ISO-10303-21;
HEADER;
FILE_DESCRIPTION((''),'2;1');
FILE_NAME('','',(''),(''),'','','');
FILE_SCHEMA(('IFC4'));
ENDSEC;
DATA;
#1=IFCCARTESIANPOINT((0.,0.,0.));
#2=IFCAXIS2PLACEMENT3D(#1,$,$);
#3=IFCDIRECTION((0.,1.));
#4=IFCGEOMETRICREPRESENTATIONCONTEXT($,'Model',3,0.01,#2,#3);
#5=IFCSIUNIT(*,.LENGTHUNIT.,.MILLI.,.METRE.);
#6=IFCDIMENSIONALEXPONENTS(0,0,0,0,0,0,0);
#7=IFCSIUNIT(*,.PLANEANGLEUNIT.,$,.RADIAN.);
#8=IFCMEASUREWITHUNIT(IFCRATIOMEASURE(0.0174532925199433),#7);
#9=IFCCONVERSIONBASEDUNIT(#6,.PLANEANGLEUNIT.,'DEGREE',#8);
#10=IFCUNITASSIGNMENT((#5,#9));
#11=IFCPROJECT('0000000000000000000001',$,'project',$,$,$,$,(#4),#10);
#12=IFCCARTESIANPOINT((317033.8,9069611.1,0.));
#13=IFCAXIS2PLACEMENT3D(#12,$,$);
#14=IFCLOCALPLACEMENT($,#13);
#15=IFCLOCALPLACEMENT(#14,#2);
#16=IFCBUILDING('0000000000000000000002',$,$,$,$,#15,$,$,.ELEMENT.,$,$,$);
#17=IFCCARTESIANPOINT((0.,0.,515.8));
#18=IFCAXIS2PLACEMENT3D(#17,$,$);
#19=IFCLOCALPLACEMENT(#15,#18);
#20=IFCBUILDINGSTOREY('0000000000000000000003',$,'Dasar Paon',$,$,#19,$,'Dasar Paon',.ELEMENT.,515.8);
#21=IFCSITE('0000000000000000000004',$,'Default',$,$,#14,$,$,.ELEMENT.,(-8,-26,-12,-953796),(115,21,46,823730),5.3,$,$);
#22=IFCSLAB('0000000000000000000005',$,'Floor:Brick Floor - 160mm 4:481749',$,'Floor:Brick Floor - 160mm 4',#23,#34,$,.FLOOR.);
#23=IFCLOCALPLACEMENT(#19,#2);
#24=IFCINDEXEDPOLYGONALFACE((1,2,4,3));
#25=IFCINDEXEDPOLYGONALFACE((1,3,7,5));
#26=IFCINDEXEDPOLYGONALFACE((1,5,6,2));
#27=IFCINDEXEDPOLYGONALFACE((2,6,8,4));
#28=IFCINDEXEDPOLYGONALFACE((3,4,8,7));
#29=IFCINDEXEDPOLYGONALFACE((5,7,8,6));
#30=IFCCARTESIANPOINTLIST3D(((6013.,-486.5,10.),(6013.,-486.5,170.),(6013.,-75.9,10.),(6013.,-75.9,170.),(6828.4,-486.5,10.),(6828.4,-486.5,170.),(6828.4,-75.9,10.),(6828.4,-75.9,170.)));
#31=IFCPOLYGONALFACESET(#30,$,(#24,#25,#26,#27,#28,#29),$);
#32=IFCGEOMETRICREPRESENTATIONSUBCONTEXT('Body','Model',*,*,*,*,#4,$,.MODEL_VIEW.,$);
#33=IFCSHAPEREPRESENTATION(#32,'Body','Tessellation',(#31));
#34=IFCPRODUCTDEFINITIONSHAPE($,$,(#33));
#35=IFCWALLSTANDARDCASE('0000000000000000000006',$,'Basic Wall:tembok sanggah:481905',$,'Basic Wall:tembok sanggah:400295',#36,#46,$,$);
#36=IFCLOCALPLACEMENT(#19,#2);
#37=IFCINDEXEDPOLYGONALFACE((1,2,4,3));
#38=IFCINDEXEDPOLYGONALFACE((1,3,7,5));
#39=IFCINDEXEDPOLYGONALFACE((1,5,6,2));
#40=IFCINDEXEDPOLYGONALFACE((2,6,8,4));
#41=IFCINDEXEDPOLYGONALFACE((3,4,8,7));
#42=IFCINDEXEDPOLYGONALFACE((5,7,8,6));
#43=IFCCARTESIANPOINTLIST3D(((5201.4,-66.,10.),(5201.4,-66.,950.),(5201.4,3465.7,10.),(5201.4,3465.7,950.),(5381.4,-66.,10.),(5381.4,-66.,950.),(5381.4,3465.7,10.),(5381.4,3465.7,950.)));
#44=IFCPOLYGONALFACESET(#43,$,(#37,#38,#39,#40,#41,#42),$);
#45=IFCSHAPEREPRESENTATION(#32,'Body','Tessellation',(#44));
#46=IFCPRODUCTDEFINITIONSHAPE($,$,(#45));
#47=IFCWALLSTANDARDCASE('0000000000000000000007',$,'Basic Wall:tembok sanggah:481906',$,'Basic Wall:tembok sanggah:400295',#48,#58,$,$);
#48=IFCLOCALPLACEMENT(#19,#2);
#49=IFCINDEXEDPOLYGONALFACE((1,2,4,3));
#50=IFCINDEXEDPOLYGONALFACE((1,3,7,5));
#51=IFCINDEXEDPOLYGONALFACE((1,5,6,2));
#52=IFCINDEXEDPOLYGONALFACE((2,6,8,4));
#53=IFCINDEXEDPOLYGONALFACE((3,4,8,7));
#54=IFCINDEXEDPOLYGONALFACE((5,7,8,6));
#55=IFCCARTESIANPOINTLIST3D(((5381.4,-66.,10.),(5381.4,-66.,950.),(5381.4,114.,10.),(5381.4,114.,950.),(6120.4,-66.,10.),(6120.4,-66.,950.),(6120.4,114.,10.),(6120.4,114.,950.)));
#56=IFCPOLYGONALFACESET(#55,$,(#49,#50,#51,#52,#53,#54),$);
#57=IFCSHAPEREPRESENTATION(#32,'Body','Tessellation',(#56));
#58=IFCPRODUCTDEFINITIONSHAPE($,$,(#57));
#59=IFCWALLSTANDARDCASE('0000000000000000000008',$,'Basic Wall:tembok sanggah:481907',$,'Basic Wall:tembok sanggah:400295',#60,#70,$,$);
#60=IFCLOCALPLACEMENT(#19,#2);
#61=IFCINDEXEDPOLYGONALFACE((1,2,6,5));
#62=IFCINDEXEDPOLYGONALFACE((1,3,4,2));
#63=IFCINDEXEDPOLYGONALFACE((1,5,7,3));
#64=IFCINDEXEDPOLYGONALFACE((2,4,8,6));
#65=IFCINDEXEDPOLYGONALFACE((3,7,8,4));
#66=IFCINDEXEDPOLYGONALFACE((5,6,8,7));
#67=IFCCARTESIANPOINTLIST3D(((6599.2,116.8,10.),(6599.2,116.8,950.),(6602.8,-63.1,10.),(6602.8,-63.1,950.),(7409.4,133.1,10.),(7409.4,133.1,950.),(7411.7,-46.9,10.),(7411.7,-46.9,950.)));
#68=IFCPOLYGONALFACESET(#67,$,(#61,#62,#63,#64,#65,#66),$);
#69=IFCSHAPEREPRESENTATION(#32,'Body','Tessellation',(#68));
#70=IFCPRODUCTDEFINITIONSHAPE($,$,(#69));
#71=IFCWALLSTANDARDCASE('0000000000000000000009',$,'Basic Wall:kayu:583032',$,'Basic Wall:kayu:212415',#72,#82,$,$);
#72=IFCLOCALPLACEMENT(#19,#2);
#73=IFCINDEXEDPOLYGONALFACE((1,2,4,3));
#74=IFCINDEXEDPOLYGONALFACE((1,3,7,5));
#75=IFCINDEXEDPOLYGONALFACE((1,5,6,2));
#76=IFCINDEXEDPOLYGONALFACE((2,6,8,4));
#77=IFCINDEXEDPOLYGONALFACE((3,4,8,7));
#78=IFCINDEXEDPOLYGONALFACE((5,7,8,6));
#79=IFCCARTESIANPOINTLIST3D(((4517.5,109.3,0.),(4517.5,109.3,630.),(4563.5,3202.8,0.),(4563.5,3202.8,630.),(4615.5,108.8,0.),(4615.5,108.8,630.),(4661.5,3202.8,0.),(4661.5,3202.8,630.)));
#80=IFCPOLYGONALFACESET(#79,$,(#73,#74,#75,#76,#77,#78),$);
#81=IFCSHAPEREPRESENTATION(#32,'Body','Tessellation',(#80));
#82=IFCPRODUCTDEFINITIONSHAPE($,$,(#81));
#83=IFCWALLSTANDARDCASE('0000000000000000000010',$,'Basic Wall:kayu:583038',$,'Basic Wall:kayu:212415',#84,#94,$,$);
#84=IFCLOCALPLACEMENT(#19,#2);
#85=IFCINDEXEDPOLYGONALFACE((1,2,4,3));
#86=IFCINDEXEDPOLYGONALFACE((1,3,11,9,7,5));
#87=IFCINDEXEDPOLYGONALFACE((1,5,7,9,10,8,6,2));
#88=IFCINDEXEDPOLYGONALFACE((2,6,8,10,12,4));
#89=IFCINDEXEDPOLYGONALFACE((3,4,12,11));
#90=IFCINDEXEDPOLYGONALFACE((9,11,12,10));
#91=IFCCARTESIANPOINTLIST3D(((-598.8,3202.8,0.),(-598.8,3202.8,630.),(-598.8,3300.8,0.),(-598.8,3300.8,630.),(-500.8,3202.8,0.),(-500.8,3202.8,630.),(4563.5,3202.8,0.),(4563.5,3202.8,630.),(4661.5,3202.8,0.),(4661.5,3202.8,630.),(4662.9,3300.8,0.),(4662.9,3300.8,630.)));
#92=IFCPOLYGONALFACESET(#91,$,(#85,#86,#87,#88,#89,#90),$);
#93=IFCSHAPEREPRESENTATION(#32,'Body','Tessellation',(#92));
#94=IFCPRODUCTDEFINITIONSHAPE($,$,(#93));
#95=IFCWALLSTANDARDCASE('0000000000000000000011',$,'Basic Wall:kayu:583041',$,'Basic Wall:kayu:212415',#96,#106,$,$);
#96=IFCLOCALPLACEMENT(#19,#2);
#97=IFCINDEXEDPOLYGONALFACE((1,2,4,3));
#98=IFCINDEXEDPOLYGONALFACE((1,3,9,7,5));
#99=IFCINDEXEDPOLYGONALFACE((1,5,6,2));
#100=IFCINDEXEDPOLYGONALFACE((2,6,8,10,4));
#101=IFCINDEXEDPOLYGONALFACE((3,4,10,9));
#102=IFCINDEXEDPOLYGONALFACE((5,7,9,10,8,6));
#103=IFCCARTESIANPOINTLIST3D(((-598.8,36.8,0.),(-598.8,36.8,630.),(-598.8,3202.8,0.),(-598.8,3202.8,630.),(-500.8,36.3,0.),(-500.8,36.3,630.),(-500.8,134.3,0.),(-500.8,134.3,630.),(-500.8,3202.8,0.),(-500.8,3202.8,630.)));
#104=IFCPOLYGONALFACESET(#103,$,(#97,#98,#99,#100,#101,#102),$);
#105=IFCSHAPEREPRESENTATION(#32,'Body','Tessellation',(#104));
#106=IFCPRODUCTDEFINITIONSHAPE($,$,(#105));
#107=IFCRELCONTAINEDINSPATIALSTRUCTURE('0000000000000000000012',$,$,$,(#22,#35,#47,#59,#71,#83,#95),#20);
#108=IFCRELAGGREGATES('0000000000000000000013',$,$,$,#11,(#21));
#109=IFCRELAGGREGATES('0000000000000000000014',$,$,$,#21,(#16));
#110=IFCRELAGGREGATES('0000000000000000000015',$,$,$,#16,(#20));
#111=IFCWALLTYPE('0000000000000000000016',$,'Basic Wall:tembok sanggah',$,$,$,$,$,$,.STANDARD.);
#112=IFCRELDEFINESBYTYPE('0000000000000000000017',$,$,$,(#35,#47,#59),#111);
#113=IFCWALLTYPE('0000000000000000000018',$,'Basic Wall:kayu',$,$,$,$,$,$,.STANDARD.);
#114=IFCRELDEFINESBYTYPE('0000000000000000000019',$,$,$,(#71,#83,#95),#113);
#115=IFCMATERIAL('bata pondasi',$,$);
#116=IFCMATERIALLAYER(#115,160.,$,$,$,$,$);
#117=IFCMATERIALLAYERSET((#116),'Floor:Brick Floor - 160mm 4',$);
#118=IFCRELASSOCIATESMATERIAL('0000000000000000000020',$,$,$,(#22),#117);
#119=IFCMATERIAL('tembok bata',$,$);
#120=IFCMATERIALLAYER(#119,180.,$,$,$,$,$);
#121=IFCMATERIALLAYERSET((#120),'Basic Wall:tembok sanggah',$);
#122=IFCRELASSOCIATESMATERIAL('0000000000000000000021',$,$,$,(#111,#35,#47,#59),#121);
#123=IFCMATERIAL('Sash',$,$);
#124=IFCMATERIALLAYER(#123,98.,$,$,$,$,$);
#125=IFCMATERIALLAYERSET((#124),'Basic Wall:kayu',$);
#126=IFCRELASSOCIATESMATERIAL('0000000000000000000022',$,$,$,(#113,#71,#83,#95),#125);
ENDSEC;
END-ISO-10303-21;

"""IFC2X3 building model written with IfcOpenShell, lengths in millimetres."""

from ifc_helpers import new_model, entity, si_unit, converted_unit, direction, frame, frame_2d, origin, place, context, subcontext, project, spatial, polyline, rectangle, outline, extrude, material, layer, layer_set, layer_usage, type_object, element, save


model = new_model("IFC2X3")

# Units and contexts
model_context = context("Model", 3, precision=0.01, world=origin(), true_north=direction((0.0, 1.0)))
body_context = subcontext(model_context, "Body", "Model", "MODEL_VIEW")
ifc_project = project(units=[si_unit("LENGTHUNIT", "METRE", prefix="MILLI"), converted_unit("PLANEANGLEUNIT", "DEGREE", entity("IfcRatioMeasure", 0.0174532925199433), si_unit("PLANEANGLEUNIT", "RADIAN"), dimensions=[0, 0, 0, 0, 0, 0, 0])], contexts=[model_context])

# Site, building, storey
site_placement = place(None, frame((317033.8, 9069611.1, 0.0)))
site = spatial("IfcSite", under=ifc_project, at=site_placement, Name="Default", CompositionType="ELEMENT", RefLatitude=(-8, -26, -12, -953796), RefLongitude=(115, 21, 46, 823730), RefElevation=5.3)
building_placement = place(site_placement, origin())
building = spatial("IfcBuilding", under=site, at=building_placement, CompositionType="ELEMENT")
storey_placement = place(building_placement, frame((0.0, 0.0, 515.8)))
storey = spatial("IfcBuildingStorey", under=building, at=storey_placement, Name="Dasar Paon", LongName="Dasar Paon", CompositionType="ELEMENT", Elevation=515.8)

# Slab
ifc_material_1 = material(Name="bata pondasi")
ifc_layer_1 = layer(ifc_material_1, 160.0)
ifc_layer_set_1 = layer_set([ifc_layer_1], Name="Floor:Brick Floor - 160mm 4")
ifc_layer_usage_1 = layer_usage(ifc_layer_set_1, "AXIS3", "POSITIVE", 0.0)
slab_1_placement = place(storey_placement, origin())
element("IfcSlab", 1, at=slab_1_placement, inside=storey, material=ifc_layer_usage_1, Name="Floor:Brick Floor - 160mm 4:481749", ObjectType="Floor:Brick Floor - 160mm 4", PredefinedType="FLOOR", context=body_context, shape_type="SweptSolid", body=[
    extrude(rectangle(XDim=410.6, YDim=815.5, at=frame_2d((0.0, 0.0), x_axis=(1.0, 0.0))), frame((6420.7, -281.2, 170.0), z_axis=(0.0, 0.0, -1.0), x_axis=(0.0, 1.0, 0.0)), (0.0, 0.0, 1.0), 160.0),
])

# Walls
ifc_material_2 = material(Name="tembok bata")
ifc_layer_2 = layer(ifc_material_2, 180.0)
ifc_layer_set_2 = layer_set([ifc_layer_2], Name="Basic Wall:tembok sanggah")
ifc_layer_usage_2 = layer_usage(ifc_layer_set_2, "AXIS2", "NEGATIVE", 90.0)
wall_type_1 = type_object("IfcWallType", Name="Basic Wall:tembok sanggah", PredefinedType="STANDARD", material=ifc_layer_set_2)
wall_1_placement = place(storey_placement, frame((5291.4, 3465.7, 10.0), z_axis=(0.0, 0.0, 1.0), x_axis=(0.0, -1.0, 0.0)))
element("IfcWallStandardCase", 2, at=wall_1_placement, inside=storey, type_object=wall_type_1, material=ifc_layer_usage_2, Name="Basic Wall:tembok sanggah:481905", ObjectType="Basic Wall:tembok sanggah:400295", context=body_context, shape_type="SweptSolid", body=[
    extrude(rectangle(XDim=3531.8, YDim=180.0, at=frame_2d((1765.9, 0.0), x_axis=(-1.0, 0.0))), origin(), (0.0, 0.0, 1.0), 940.0),
])
ifc_layer_usage_3 = layer_usage(ifc_layer_set_2, "AXIS2", "NEGATIVE", 90.0)
wall_2_placement = place(storey_placement, frame((5381.4, 24.0, 10.0)))
element("IfcWallStandardCase", 3, at=wall_2_placement, inside=storey, type_object=wall_type_1, material=ifc_layer_usage_3, Name="Basic Wall:tembok sanggah:481906", ObjectType="Basic Wall:tembok sanggah:400295", context=body_context, shape_type="SweptSolid", body=[
    extrude(rectangle(XDim=739.0, YDim=180.0, at=frame_2d((369.5, 0.0), x_axis=(-1.0, 0.0))), origin(), (0.0, 0.0, 1.0), 940.0),
])
ifc_layer_usage_4 = layer_usage(ifc_layer_set_2, "AXIS2", "NEGATIVE", 90.0)
wall_3_placement = place(storey_placement, frame((6601.0, 26.9, 10.0), z_axis=(0.0, 0.0, 1.0), x_axis=(0.999798, 0.020086, 0.0)))
element("IfcWallStandardCase", 4, at=wall_3_placement, inside=storey, type_object=wall_type_1, material=ifc_layer_usage_4, Name="Basic Wall:tembok sanggah:481907", ObjectType="Basic Wall:tembok sanggah:400295", context=body_context, shape_type="SweptSolid", body=[
    extrude(outline(polyline([(809.1, -90.0), (810.4, 90.0), (0.0, 90.0), (0.0, -90.0), (809.1, -90.0)])), origin(), (0.0, 0.0, 1.0), 940.0),
])

# Shared definitions
ifc_material_3 = material(Name="Sash")

# Walls
ifc_layer_3 = layer(ifc_material_3, 98.0)
ifc_layer_set_3 = layer_set([ifc_layer_3], Name="Basic Wall:kayu")
ifc_layer_usage_5 = layer_usage(ifc_layer_set_3, "AXIS2", "NEGATIVE", 49.0)
wall_type_2 = type_object("IfcWallType", Name="Basic Wall:kayu", PredefinedType="STANDARD", material=ifc_layer_set_3)
wall_4_placement = place(storey_placement, frame((4566.5, 108.5, 0.0), z_axis=(0.0, 0.0, 1.0), x_axis=(0.014861, 0.99989, 0.0)))
element("IfcWallStandardCase", 5, at=wall_4_placement, inside=storey, type_object=wall_type_2, material=ifc_layer_usage_5, Name="Basic Wall:kayu:583032", ObjectType="Basic Wall:kayu:212415", context=body_context, shape_type="SweptSolid", body=[
    extrude(outline(polyline([(3095.3, -49.0), (3093.9, 49.0), (0.0, 49.0), (1.0, -49.0), (3095.3, -49.0)])), origin(), (0.0, 0.0, 1.0), 630.0),
])
ifc_layer_usage_6 = layer_usage(ifc_layer_set_3, "AXIS2", "POSITIVE", -49.0)
wall_5_placement = place(storey_placement, frame((4662.9, 3251.8, 0.0), z_axis=(0.0, 0.0, 1.0), x_axis=(-1.0, 0.0, 0.0)))
element("IfcWallStandardCase", 6, at=wall_5_placement, inside=storey, type_object=wall_type_2, material=ifc_layer_usage_6, Name="Basic Wall:kayu:583038", ObjectType="Basic Wall:kayu:212415", context=body_context, shape_type="SweptSolid", body=[
    extrude(outline(polyline([(5261.8, -49.0), (5261.8, 49.0), (5163.8, 49.0), (99.5, 49.0), (1.5, 49.0), (0.0, -49.0), (5261.8, -49.0)])), origin(), (0.0, 0.0, 1.0), 630.0),
])
ifc_layer_usage_7 = layer_usage(ifc_layer_set_3, "AXIS2", "POSITIVE", -49.0)
wall_6_placement = place(storey_placement, frame((-549.8, 3202.8, 0.0), z_axis=(0.0, 0.0, 1.0), x_axis=(0.0, -1.0, 0.0)))
element("IfcWallStandardCase", 7, at=wall_6_placement, inside=storey, type_object=wall_type_2, material=ifc_layer_usage_7, Name="Basic Wall:kayu:583041", ObjectType="Basic Wall:kayu:212415", context=body_context, shape_type="SweptSolid", body=[
    extrude(outline(polyline([(3166.0, -49.0), (3166.5, 49.0), (3068.5, 49.0), (0.0, 49.0), (0.0, -49.0), (3166.0, -49.0)])), origin(), (0.0, 0.0, 1.0), 630.0),
])

save(model, "model.ifc")
